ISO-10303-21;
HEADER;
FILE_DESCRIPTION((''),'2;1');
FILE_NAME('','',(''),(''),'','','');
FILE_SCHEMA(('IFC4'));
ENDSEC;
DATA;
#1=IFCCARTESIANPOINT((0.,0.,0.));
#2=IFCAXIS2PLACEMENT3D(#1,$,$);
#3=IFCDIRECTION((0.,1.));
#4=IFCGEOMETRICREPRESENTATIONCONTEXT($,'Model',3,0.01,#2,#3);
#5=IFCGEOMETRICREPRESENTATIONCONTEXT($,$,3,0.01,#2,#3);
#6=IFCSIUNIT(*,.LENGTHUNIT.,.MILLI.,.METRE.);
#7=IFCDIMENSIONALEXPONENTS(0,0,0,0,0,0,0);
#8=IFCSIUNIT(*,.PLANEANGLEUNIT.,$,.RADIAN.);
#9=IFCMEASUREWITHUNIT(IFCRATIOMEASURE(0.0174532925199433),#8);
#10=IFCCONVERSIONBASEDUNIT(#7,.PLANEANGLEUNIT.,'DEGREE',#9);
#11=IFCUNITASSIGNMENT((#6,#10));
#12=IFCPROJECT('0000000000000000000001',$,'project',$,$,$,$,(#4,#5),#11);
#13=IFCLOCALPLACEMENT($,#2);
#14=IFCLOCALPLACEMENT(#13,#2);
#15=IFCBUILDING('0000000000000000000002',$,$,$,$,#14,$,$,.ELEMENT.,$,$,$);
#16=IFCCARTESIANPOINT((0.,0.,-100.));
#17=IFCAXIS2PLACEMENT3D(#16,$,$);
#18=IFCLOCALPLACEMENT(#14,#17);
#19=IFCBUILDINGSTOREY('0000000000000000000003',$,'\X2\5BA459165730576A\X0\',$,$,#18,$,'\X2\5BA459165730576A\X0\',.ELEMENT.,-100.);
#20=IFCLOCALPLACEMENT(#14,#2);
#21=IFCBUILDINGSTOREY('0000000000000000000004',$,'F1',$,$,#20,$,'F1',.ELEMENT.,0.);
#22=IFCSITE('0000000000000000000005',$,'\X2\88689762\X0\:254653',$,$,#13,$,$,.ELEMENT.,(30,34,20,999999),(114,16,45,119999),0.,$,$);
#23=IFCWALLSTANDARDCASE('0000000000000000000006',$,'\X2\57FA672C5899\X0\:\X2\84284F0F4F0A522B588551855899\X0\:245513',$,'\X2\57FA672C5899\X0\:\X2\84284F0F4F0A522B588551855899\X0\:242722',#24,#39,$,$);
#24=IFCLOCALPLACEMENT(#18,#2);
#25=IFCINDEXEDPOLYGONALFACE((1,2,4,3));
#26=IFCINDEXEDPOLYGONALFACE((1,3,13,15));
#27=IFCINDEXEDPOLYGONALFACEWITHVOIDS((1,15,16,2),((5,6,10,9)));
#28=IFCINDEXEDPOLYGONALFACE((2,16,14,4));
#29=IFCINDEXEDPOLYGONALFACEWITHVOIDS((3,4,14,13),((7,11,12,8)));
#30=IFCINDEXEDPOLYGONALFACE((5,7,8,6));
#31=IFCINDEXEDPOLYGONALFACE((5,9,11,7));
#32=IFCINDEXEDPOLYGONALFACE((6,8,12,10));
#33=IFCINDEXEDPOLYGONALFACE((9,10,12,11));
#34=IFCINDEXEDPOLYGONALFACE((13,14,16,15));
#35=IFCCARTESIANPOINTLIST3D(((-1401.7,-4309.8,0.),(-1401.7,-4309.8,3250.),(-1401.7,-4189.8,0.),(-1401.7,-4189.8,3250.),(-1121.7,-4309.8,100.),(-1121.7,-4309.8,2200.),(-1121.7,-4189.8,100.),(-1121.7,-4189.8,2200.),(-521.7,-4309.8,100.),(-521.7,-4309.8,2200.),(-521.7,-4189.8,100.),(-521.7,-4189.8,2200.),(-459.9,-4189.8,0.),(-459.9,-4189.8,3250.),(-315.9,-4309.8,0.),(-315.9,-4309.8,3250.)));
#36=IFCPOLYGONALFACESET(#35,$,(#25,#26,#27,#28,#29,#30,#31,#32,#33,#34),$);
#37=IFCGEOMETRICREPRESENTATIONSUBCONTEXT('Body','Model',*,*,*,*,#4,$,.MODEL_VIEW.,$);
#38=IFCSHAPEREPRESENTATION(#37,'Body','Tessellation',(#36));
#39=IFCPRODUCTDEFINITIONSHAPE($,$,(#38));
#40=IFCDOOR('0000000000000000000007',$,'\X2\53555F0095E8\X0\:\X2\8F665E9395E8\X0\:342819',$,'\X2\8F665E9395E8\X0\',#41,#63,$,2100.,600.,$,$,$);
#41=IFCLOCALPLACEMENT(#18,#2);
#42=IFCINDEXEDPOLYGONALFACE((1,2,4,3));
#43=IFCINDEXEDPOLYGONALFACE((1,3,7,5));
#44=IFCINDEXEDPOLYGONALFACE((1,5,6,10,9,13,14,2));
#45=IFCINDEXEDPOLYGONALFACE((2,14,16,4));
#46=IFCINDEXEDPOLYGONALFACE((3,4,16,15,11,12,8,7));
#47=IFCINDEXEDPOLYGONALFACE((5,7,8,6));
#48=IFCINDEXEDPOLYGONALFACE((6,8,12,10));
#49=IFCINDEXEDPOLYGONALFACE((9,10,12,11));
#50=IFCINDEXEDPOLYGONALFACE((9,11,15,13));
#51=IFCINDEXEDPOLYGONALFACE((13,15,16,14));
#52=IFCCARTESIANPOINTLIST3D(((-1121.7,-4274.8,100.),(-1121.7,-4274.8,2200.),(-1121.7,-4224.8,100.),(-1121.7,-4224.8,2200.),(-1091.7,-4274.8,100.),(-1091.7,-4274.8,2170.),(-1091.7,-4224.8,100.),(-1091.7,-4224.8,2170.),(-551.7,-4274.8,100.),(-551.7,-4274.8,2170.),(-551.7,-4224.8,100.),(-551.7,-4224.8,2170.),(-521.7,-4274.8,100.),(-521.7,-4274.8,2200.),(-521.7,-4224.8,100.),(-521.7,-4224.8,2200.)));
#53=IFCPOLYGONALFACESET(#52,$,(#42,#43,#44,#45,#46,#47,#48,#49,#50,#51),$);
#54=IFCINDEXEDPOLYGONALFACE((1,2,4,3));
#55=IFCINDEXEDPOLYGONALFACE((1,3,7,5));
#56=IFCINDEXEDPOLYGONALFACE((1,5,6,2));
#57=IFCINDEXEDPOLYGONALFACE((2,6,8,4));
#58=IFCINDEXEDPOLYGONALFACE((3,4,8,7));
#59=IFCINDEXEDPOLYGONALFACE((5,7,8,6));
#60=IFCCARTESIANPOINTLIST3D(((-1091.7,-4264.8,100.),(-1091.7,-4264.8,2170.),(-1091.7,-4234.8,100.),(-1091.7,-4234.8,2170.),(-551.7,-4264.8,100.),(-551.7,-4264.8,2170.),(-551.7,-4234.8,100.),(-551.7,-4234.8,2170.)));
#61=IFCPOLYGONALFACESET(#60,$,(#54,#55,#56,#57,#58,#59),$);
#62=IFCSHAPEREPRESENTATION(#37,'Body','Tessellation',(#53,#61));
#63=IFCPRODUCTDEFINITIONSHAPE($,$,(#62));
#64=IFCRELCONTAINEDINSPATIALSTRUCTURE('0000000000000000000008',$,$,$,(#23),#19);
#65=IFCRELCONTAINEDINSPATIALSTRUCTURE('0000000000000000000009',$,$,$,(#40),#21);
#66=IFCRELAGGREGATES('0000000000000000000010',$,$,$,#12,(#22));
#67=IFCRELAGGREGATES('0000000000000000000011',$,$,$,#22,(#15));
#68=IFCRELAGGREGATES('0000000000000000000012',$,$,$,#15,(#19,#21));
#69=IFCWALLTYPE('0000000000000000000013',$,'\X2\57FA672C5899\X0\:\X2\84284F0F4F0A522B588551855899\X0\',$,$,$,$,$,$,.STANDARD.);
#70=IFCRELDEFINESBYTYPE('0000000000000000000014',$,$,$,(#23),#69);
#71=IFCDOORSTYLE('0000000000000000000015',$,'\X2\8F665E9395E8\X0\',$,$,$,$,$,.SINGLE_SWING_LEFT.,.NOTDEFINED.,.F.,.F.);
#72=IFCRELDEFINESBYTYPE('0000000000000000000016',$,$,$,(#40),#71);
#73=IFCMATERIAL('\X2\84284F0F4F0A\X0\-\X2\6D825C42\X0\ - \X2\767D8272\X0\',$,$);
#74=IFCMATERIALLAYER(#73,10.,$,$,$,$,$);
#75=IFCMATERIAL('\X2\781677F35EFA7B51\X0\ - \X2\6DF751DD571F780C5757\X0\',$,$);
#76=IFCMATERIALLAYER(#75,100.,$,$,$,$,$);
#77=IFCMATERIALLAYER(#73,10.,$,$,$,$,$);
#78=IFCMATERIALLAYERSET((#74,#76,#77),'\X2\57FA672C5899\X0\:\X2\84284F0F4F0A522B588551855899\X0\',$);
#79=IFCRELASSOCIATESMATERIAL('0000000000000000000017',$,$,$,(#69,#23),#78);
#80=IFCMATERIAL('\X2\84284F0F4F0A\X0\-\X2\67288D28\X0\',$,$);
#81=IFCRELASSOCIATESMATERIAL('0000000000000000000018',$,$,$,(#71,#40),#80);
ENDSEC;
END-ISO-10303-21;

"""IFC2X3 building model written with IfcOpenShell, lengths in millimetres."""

from ifc_helpers import new_model, entity, si_unit, converted_unit, direction, frame, frame_2d, origin, origin_2d_with_axis, place, context, subcontext, project, spatial, polyline, rectangle, outline, extrude, clip, bounded_halfspace, source, transform, mapped, material, layer, layer_set, layer_usage, type_object, type_shapes, element, fill, save


model = new_model("IFC2X3")

# Units and contexts
model_context = context("Model", 3, precision=0.01, world=origin(), true_north=direction((0.0, 1.0)))
context_of_model = context(None, 3, precision=0.01, world=origin(), true_north=direction((0.0, 1.0)))
body_context = subcontext(model_context, "Body", "Model", "MODEL_VIEW")
ifc_project = project(units=[si_unit("LENGTHUNIT", "METRE", prefix="MILLI"), converted_unit("PLANEANGLEUNIT", "DEGREE", entity("IfcRatioMeasure", 0.0174532925199433), si_unit("PLANEANGLEUNIT", "RADIAN"), dimensions=[0, 0, 0, 0, 0, 0, 0])], contexts=[model_context, context_of_model])

# Site, building, storey
site_placement = place(None, origin())
site = spatial("IfcSite", under=ifc_project, at=site_placement, Name="表面:254653", CompositionType="ELEMENT", RefLatitude=(30, 34, 20, 999999), RefLongitude=(114, 16, 45, 119999), RefElevation=0.0)
building_placement = place(site_placement, origin())
building = spatial("IfcBuilding", under=site, at=building_placement, CompositionType="ELEMENT")
storey_1_placement = place(building_placement, frame((0.0, 0.0, -100.0)))
storey_1 = spatial("IfcBuildingStorey", under=building, at=storey_1_placement, Name="室外地坪", LongName="室外地坪", CompositionType="ELEMENT", Elevation=-100.0)

# Shared definitions
ifc_material_1 = material(Name="萨伏伊-涂层 - 白色")

# Wall, opening
ifc_layer_1 = layer(ifc_material_1, 10.0)
ifc_material_2 = material(Name="砖石建筑 - 混凝土砌块")
ifc_layer_2 = layer(ifc_material_2, 100.0)
ifc_layer_3 = layer(ifc_material_1, 10.0)
ifc_layer_set_1 = layer_set([ifc_layer_1, ifc_layer_2, ifc_layer_3], Name="基本墙:萨伏伊别墅内墙")
ifc_layer_usage_1 = layer_usage(ifc_layer_set_1, "AXIS2", "NEGATIVE", 60.0)
wall_type_1 = type_object("IfcWallType", Name="基本墙:萨伏伊别墅内墙", PredefinedType="STANDARD", material=ifc_layer_set_1)
wall_1_placement = place(storey_1_placement, frame((-1401.7, -4249.8, 0.0)))
wall_1 = element("IfcWallStandardCase", 1, at=wall_1_placement, inside=storey_1, type_object=wall_type_1, material=ifc_layer_usage_1, Name="基本墙:萨伏伊别墅内墙:245513", ObjectType="基本墙:萨伏伊别墅内墙:242722", context=body_context, shape_type="Clipping", body=[
    clip(extrude(outline(polyline([(1085.7, -60.0), (941.7, 60.0), (0.0, 60.0), (0.0, -60.0), (1085.7, -60.0)])), origin(), (0.0, 0.0, 1.0), 3250.0), bounded_halfspace(frame((0.0, -60.0, 3250.0), z_axis=(0.0, 0.0, -1.0), x_axis=(0.0, -1.0, 0.0)), True, frame((0.0, -60.0, 3250.0)), polyline([(0.0, 0.0), (898.3, 0.0), (1085.7, 0.0), (941.7, 120.0), (120.0, 120.0), (0.0, 120.0), (0.0, 0.0)]))),
])
opening_placement = place(wall_1_placement, frame((280.0, -60.0, 100.0)))
opening = element("IfcOpeningElement", 2, at=opening_placement, cuts=wall_1, ObjectType="Opening", context=body_context, shape_type="SweptSolid", body=[
    extrude(rectangle(XDim=2100.0, YDim=600.0, at=frame_2d((1050.0, 300.0), x_axis=(1.0, 0.0))), frame((0.0, 0.0, 0.0), z_axis=(0.0, 1.0, 0.0), x_axis=(0.0, 0.0, 1.0)), (0.0, 0.0, 1.0), 120.0),
])

# Shared definitions
storey_2_placement = place(building_placement, origin())
storey_2 = spatial("IfcBuildingStorey", under=building, at=storey_2_placement, Name="F1", LongName="F1", CompositionType="ELEMENT", Elevation=0.0)

# Door
ifc_material_3 = material(Name="萨伏伊-木质")
door_style_1 = type_object("IfcDoorStyle", Name="车库门", ConstructionType="NOTDEFINED", OperationType="SINGLE_SWING_LEFT", ParameterTakesPrecedence=False, Sizeable=False, material=ifc_material_3)
shared_shape_1 = source(origin(), body_context, "Body", "SweptSolid", [
    extrude(outline(polyline([(-1057.5, -300.0), (1042.5, -300.0), (1042.5, -270.0), (-1027.5, -270.0), (-1027.5, 270.0), (1042.5, 270.0), (1042.5, 300.0), (-1057.5, 300.0), (-1057.5, -300.0)])), frame((300.0, 35.0, 1042.5), z_axis=(0.0, 1.0, 0.0), x_axis=(0.0, 0.0, -1.0)), (0.0, 0.0, 1.0), 50.0),
    extrude(rectangle(XDim=30.0, YDim=540.0, at=origin_2d_with_axis()), frame((300.0, 60.0, 0.0), z_axis=(0.0, 0.0, 1.0), x_axis=(0.0, 1.0, 0.0)), (0.0, 0.0, 1.0), 2070.0),
])
type_shapes(door_style_1, [shared_shape_1])
door_1_placement = place(opening_placement, origin())
door_1 = element("IfcDoor", 3, at=door_1_placement, inside=storey_2, type_object=door_style_1, material=ifc_material_3, Name="单开门:车库门:342819", ObjectType="车库门", OverallHeight=2100.0, OverallWidth=600.0, context=body_context, shape_type="MappedRepresentation", body=[
    mapped(shared_shape_1, transform((0.0, 0.0, 0.0), scale=1.0)),
])
fill(opening, door_1)

save(model, "model.ifc")
